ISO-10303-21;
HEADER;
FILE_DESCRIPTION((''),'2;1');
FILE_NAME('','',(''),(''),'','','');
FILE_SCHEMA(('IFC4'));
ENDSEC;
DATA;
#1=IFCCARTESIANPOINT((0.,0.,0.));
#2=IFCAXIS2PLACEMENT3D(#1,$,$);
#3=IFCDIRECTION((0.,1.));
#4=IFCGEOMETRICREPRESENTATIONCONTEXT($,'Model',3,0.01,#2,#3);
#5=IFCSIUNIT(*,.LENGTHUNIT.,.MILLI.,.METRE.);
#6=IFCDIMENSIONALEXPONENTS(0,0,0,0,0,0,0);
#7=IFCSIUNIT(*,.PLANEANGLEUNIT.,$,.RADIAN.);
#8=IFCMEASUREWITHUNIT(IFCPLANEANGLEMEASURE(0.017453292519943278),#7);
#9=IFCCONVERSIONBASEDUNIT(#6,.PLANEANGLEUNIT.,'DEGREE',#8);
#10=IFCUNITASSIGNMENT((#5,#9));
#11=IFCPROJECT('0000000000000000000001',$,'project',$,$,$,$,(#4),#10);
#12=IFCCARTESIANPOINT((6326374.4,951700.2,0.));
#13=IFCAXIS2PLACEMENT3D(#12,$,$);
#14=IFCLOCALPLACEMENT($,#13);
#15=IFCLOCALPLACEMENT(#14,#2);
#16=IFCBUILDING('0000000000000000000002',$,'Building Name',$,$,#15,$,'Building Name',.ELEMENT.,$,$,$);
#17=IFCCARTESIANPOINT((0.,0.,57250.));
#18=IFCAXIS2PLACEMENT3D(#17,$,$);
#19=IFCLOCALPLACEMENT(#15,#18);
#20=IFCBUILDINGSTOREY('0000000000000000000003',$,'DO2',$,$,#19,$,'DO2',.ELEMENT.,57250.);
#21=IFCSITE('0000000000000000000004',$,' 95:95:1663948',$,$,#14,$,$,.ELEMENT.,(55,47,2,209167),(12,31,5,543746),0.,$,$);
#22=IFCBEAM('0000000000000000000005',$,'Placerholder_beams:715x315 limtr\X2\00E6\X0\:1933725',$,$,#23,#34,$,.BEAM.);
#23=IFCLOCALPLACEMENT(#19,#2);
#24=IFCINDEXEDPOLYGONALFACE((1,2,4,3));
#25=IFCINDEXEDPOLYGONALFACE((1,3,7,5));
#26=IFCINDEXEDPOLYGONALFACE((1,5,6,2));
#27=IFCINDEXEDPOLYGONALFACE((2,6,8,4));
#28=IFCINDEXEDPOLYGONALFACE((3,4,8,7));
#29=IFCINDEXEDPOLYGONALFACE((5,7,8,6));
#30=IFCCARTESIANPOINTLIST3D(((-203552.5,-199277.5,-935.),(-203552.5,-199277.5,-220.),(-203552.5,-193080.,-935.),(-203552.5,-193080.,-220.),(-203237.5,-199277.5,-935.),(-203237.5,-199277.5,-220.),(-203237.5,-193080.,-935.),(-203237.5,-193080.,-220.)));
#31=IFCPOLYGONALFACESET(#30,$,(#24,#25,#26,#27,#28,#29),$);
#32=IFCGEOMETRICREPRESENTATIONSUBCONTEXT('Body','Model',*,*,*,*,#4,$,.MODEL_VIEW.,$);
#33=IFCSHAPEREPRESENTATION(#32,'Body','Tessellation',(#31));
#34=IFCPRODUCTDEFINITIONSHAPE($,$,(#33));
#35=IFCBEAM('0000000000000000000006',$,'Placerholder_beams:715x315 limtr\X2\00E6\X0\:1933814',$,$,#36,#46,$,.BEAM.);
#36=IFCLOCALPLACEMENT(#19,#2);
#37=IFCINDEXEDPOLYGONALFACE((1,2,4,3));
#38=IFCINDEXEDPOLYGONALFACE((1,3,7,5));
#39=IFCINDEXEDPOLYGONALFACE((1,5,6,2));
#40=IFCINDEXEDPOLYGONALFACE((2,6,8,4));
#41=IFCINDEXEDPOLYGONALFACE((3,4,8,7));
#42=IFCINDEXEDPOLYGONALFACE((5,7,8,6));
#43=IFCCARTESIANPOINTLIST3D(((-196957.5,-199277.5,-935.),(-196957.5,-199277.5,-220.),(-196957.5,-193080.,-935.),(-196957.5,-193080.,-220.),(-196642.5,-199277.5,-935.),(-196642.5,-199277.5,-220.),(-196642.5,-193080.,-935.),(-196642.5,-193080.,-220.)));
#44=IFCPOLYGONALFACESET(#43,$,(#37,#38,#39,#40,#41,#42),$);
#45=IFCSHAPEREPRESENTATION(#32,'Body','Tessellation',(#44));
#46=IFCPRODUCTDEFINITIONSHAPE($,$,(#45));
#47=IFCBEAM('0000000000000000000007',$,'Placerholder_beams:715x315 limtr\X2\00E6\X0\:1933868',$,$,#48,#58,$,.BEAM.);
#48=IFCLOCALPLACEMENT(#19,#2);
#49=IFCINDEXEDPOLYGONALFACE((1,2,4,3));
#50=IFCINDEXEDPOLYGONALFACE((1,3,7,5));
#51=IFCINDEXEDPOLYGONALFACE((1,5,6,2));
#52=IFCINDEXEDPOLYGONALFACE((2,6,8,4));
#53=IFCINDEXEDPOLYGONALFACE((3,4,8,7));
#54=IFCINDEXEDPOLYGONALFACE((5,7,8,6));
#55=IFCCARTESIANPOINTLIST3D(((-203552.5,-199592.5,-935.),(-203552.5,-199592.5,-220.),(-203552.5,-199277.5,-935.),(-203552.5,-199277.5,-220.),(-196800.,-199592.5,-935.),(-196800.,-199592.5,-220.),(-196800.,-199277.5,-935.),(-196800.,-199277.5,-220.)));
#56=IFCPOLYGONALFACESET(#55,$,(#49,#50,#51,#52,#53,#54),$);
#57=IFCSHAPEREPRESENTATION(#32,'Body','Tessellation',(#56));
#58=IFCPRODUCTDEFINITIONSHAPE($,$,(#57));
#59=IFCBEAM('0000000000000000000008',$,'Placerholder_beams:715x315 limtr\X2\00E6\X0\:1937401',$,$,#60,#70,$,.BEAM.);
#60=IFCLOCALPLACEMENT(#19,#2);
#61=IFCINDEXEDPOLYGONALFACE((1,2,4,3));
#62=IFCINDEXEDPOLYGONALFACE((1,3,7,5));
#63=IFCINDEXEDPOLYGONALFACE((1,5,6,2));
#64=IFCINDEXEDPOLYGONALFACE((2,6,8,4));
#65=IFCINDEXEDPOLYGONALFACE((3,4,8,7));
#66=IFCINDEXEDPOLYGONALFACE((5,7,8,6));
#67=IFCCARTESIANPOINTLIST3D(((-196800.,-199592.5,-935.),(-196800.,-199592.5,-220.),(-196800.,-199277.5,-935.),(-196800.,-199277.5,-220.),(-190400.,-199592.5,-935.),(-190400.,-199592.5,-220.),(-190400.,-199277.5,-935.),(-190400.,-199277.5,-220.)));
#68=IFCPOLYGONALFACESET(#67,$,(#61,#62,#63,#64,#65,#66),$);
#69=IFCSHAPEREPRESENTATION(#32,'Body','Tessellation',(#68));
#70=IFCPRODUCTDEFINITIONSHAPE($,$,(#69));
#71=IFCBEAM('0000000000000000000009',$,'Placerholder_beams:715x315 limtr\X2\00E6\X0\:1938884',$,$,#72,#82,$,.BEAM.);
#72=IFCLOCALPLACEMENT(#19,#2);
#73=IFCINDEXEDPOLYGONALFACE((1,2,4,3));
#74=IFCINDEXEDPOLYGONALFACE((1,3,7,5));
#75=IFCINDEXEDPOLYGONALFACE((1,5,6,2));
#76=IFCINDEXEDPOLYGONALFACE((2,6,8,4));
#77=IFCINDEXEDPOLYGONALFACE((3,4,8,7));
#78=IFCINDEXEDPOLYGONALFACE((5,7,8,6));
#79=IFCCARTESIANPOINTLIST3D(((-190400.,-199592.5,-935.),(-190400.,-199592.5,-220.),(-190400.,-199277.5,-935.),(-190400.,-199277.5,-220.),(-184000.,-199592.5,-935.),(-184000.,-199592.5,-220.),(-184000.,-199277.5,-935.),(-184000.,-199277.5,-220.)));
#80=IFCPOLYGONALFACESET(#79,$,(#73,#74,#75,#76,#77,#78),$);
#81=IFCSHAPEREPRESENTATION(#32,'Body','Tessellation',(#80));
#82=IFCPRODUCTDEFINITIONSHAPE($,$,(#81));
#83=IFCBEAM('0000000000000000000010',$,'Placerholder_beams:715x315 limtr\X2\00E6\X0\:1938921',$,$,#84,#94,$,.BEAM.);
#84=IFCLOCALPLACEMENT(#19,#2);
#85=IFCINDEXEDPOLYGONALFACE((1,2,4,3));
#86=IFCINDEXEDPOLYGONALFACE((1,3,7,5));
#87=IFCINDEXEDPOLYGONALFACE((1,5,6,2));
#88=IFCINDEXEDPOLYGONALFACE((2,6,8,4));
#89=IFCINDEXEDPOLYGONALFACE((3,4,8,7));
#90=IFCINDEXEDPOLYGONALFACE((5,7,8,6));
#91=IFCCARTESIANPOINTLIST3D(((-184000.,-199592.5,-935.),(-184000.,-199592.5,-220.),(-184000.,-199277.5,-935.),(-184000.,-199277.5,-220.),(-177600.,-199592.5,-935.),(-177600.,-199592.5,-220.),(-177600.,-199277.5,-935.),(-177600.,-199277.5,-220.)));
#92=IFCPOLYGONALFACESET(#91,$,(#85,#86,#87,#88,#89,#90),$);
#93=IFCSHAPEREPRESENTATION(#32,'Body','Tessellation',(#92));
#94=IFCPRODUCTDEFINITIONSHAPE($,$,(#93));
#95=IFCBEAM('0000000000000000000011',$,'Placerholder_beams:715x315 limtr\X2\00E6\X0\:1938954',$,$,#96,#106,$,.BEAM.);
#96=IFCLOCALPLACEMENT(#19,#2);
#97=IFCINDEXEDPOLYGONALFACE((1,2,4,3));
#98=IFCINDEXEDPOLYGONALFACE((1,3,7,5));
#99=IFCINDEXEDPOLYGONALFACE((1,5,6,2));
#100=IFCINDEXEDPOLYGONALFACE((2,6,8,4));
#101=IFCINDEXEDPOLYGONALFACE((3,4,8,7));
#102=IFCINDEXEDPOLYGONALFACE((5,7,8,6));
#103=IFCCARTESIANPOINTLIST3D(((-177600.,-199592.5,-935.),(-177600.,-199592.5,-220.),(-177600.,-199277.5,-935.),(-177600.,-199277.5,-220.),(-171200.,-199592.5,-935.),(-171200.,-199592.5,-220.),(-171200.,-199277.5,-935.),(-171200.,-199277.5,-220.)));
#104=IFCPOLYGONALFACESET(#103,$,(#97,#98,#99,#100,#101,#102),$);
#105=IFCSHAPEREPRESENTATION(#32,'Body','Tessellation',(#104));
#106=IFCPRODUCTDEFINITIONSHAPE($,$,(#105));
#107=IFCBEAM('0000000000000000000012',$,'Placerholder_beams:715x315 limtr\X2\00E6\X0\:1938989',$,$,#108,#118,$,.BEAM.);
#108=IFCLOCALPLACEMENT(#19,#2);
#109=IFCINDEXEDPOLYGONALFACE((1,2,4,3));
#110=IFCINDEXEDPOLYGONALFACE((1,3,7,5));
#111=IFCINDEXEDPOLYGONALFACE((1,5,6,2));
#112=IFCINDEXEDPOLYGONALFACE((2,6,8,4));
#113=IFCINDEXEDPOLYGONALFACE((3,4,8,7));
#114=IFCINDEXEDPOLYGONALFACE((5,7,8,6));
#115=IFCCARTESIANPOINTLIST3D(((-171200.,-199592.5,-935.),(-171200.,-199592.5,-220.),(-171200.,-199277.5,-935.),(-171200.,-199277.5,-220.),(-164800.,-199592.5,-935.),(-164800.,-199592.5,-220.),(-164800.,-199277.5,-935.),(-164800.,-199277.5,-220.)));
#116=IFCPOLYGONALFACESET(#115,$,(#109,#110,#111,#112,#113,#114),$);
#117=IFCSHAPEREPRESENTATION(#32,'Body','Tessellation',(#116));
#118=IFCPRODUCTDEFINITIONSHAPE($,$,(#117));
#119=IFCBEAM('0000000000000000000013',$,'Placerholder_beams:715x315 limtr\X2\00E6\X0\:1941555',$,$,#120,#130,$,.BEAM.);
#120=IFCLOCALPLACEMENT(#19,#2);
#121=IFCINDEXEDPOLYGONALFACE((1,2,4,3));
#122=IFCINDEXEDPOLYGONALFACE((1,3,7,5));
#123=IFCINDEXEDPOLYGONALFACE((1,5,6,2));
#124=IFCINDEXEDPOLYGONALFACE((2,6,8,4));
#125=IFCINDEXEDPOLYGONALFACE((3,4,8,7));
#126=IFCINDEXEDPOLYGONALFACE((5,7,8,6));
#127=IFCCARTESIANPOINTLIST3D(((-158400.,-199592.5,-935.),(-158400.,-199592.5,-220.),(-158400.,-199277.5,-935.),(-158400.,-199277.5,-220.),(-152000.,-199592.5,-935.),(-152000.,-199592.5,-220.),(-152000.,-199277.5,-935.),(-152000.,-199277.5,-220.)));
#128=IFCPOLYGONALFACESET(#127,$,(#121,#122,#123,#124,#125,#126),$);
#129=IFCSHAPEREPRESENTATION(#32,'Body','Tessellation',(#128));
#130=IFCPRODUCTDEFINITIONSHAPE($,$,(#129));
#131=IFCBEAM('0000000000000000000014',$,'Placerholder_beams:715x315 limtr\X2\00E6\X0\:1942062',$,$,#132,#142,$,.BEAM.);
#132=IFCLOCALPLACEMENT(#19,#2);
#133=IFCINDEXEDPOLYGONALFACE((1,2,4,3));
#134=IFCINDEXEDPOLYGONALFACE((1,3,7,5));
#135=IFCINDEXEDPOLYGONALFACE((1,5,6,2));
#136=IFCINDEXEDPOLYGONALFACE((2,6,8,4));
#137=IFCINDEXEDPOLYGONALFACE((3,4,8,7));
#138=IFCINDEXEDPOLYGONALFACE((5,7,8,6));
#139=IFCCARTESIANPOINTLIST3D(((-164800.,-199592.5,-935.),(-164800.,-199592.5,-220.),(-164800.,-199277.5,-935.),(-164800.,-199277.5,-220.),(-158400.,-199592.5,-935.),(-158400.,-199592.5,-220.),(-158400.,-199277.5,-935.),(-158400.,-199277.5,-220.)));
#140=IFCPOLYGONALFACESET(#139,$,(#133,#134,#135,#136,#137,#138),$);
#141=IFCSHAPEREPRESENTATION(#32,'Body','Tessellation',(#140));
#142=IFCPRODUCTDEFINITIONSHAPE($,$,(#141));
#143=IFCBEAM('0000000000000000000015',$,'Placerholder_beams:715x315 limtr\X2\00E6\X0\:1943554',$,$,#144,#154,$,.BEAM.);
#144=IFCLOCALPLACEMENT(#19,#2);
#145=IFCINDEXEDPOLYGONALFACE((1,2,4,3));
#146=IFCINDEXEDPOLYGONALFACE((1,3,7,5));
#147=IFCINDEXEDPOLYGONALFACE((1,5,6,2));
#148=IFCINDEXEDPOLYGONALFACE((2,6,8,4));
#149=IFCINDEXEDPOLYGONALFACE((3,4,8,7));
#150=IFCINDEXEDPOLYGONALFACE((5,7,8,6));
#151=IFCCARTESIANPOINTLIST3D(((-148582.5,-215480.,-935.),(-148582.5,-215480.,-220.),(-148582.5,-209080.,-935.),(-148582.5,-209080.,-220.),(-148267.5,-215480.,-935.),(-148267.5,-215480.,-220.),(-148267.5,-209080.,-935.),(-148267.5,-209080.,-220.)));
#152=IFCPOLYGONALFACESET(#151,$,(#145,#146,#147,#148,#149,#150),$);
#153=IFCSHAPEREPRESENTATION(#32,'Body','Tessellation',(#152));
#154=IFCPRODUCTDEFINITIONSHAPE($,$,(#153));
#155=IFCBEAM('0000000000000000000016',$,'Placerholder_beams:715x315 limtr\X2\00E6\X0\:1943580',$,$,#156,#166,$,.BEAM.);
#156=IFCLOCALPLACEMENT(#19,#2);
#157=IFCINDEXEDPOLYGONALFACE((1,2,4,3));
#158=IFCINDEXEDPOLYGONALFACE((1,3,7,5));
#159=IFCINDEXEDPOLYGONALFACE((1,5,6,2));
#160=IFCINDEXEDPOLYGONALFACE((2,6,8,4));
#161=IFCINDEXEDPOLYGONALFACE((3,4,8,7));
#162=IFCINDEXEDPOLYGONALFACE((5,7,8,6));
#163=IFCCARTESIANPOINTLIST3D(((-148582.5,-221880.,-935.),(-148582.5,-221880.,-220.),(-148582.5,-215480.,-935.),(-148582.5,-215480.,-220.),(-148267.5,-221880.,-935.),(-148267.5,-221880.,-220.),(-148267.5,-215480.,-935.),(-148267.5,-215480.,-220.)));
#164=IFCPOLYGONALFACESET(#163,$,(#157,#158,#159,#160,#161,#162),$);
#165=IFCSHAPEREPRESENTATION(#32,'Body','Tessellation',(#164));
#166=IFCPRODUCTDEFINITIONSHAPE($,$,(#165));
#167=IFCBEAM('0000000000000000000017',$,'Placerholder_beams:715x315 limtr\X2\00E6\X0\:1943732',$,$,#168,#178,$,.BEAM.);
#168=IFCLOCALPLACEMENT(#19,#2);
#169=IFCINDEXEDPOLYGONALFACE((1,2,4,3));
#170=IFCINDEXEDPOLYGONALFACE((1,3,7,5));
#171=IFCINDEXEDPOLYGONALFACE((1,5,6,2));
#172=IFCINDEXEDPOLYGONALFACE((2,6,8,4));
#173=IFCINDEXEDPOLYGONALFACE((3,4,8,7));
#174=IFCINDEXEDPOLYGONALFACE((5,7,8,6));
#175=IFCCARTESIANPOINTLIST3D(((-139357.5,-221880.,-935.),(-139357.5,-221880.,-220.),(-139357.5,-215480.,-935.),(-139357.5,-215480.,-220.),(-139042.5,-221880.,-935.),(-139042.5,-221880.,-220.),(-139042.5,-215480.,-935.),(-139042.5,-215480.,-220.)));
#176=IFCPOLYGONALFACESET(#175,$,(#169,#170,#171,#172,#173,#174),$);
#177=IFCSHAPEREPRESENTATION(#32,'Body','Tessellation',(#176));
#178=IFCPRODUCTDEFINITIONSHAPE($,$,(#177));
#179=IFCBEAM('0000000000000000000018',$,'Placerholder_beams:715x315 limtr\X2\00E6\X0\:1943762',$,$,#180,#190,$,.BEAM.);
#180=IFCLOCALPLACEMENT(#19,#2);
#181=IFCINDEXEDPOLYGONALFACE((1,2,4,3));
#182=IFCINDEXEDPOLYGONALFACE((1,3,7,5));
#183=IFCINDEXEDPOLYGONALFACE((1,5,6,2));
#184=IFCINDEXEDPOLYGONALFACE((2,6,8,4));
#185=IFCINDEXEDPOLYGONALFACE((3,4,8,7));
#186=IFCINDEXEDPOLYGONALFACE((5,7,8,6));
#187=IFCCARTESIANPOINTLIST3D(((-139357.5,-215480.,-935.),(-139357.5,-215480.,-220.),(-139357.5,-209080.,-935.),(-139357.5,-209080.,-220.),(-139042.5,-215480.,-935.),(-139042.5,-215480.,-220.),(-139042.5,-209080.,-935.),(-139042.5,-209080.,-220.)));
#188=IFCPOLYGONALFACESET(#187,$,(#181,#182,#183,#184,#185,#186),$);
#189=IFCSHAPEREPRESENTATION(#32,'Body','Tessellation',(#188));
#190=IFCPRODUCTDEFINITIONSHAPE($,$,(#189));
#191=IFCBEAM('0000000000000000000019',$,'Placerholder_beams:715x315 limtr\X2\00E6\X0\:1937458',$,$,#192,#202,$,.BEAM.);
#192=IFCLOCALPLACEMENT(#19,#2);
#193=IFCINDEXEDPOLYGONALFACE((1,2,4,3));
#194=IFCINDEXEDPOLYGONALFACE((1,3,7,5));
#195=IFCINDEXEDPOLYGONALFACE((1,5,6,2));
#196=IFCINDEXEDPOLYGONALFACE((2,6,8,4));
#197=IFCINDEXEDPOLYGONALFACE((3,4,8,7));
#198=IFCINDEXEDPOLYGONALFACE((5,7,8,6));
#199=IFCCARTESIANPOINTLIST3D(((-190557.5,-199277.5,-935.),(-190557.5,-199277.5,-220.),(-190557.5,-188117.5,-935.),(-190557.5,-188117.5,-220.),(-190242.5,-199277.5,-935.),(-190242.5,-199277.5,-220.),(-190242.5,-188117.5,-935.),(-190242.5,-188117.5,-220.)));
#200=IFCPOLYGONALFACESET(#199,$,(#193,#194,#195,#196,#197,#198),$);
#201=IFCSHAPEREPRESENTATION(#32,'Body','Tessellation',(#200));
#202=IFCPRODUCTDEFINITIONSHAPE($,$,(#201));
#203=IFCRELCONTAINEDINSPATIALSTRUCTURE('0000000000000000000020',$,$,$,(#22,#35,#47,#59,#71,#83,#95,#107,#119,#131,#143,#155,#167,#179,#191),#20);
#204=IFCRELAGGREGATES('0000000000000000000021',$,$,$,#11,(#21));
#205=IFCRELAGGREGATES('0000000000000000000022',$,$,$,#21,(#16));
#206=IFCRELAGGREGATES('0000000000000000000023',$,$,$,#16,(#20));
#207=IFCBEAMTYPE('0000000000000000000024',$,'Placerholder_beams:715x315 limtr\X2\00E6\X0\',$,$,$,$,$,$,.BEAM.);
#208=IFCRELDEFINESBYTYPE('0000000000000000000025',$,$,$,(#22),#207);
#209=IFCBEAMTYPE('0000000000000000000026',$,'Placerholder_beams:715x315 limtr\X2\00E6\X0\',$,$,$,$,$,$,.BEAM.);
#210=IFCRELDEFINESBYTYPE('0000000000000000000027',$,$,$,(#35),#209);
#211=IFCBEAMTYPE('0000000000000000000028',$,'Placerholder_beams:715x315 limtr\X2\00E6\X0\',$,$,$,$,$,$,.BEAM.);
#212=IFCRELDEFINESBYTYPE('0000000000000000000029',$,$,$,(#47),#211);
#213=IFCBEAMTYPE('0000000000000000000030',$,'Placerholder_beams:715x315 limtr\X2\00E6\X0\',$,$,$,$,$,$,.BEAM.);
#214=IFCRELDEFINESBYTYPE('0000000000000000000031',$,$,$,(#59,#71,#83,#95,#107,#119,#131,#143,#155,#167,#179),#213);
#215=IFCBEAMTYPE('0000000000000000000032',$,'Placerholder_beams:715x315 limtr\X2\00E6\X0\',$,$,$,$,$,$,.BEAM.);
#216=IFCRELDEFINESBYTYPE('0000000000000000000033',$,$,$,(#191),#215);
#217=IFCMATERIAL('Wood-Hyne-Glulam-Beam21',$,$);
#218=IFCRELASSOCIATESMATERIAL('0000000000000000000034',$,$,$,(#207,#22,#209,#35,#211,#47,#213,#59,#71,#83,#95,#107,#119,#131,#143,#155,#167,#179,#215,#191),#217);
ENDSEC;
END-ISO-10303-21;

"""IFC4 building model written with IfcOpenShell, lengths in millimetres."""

from ifc_helpers import new_model, entity, si_unit, converted_unit, direction, frame, origin, place, context, subcontext, project, spatial, indexed_curve, outline, extrude, source, transform, mapped, material, type_object, type_shapes, element, save


model = new_model("IFC4")

# Units and contexts
model_context = context("Model", 3, precision=0.01, world=origin(), true_north=direction((0.0, 1.0)))
body_context = subcontext(model_context, "Body", "Model", "MODEL_VIEW")
ifc_project = project(units=[si_unit("LENGTHUNIT", "METRE", prefix="MILLI"), converted_unit("PLANEANGLEUNIT", "DEGREE", entity("IfcPlaneAngleMeasure", 0.017453292519943278), si_unit("PLANEANGLEUNIT", "RADIAN"), dimensions=[0, 0, 0, 0, 0, 0, 0])], contexts=[model_context])

# Site, building, storey
site_placement = place(None, frame((6326374.4, 951700.2, 0.0)))
site = spatial("IfcSite", under=ifc_project, at=site_placement, Name=" 95:95:1663948", CompositionType="ELEMENT", RefLatitude=(55, 47, 2, 209167), RefLongitude=(12, 31, 5, 543746), RefElevation=0.0)
building_placement = place(site_placement, origin())
building = spatial("IfcBuilding", under=site, at=building_placement, Name="Building Name", LongName="Building Name", CompositionType="ELEMENT")
storey_placement = place(building_placement, frame((0.0, 0.0, 57250.0)))
storey = spatial("IfcBuildingStorey", under=building, at=storey_placement, Name="DO2", LongName="DO2", CompositionType="ELEMENT", Elevation=57250.0)

# Beams
ifc_material = material(Name="Wood-Hyne-Glulam-Beam21")
beam_type_1 = type_object("IfcBeamType", Name="Placerholder_beams:715x315 limtræ", PredefinedType="BEAM", material=ifc_material)
shared_shape_1 = source(origin(), body_context, "Body", "SweptSolid", [
    extrude(outline(indexed_curve([(-3098.7, -157.5), (3098.7, -157.5), (3098.7, 157.5), (-3098.7, 157.5), (-3098.7, -157.5)], self_intersect=False)), frame((28.8, 0.0, -357.5)), (0.0, 0.0, 1.0), 715.0),
])
type_shapes(beam_type_1, [shared_shape_1])
beam_1_placement = place(storey_placement, frame((-203395.0, -196207.5, -577.5), z_axis=(0.0, 0.0, 1.0), x_axis=(0.0, 1.0, 0.0)))
element("IfcBeam", 1, at=beam_1_placement, inside=storey, type_object=beam_type_1, material=ifc_material, Name="Placerholder_beams:715x315 limtræ:1933725", PredefinedType="BEAM", context=body_context, shape_type="MappedRepresentation", body=[
    mapped(shared_shape_1, transform((0.0, 0.0, 0.0), scale=1.0)),
])
beam_type_2 = type_object("IfcBeamType", Name="Placerholder_beams:715x315 limtræ", PredefinedType="BEAM", material=ifc_material)
shared_shape_2 = source(origin(), body_context, "Body", "SweptSolid", [
    extrude(outline(indexed_curve([(-3098.7, -157.5), (3098.7, -157.5), (3098.7, 157.5), (-3098.7, 157.5), (-3098.7, -157.5)], self_intersect=False)), frame((78.8, 0.0, -357.5)), (0.0, 0.0, 1.0), 715.0),
])
type_shapes(beam_type_2, [shared_shape_2])
beam_2_placement = place(storey_placement, frame((-196800.0, -196257.5, -577.5), z_axis=(0.0, 0.0, 1.0), x_axis=(0.0, 1.0, 0.0)))
element("IfcBeam", 2, at=beam_2_placement, inside=storey, type_object=beam_type_2, material=ifc_material, Name="Placerholder_beams:715x315 limtræ:1933814", PredefinedType="BEAM", context=body_context, shape_type="MappedRepresentation", body=[
    mapped(shared_shape_2, transform((0.0, 0.0, 0.0), scale=1.0)),
])
beam_type_3 = type_object("IfcBeamType", Name="Placerholder_beams:715x315 limtræ", PredefinedType="BEAM", material=ifc_material)
shared_shape_3 = source(origin(), body_context, "Body", "SweptSolid", [
    extrude(outline(indexed_curve([(-3376.2, -157.5), (3376.2, -157.5), (3376.2, 157.5), (-3376.2, 157.5), (-3376.2, -157.5)], self_intersect=False)), frame((78.7, 0.0, -357.5)), (0.0, 0.0, 1.0), 715.0),
])
type_shapes(beam_type_3, [shared_shape_3])
beam_3_placement = place(storey_placement, frame((-200097.5, -199435.0, -577.5), z_axis=(0.0, 0.0, 1.0), x_axis=(-1.0, 0.0, 0.0)))
element("IfcBeam", 3, at=beam_3_placement, inside=storey, type_object=beam_type_3, material=ifc_material, Name="Placerholder_beams:715x315 limtræ:1933868", PredefinedType="BEAM", context=body_context, shape_type="MappedRepresentation", body=[
    mapped(shared_shape_3, transform((0.0, 0.0, 0.0), scale=1.0)),
])
beam_type_4 = type_object("IfcBeamType", Name="Placerholder_beams:715x315 limtræ", PredefinedType="BEAM", material=ifc_material)
shared_shape_4 = source(origin(), body_context, "Body", "SweptSolid", [
    extrude(outline(indexed_curve([(-3200.0, -157.5), (3200.0, -157.5), (3200.0, 157.5), (-3200.0, 157.5), (-3200.0, -157.5)], self_intersect=False)), frame((0.0, 0.0, -357.5)), (0.0, 0.0, 1.0), 715.0),
])
type_shapes(beam_type_4, [shared_shape_4])
for number, where, name in (
    (4, (-193600.0, -199435.0, -577.5), "Placerholder_beams:715x315 limtræ:1937401"),
    (5, (-187200.0, -199435.0, -577.5), "Placerholder_beams:715x315 limtræ:1938884"),
    (6, (-180800.0, -199435.0, -577.5), "Placerholder_beams:715x315 limtræ:1938921"),
    (7, (-174400.0, -199435.0, -577.5), "Placerholder_beams:715x315 limtræ:1938954"),
    (8, (-168000.0, -199435.0, -577.5), "Placerholder_beams:715x315 limtræ:1938989"),
):
    element("IfcBeam", number, at=place(storey_placement, frame(where)), inside=storey, type_object=beam_type_4, material=ifc_material, Name=name, PredefinedType="BEAM", context=body_context, shape_type="MappedRepresentation", body=[
        mapped(shared_shape_4, transform((0.0, 0.0, 0.0), scale=1.0)),
    ])
beam_4_placement = place(storey_placement, frame((-155200.0, -199435.0, -577.5), z_axis=(0.0, 0.0, 1.0), x_axis=(-1.0, 0.0, 0.0)))
element("IfcBeam", 9, at=beam_4_placement, inside=storey, type_object=beam_type_4, material=ifc_material, Name="Placerholder_beams:715x315 limtræ:1941555", PredefinedType="BEAM", context=body_context, shape_type="MappedRepresentation", body=[
    mapped(shared_shape_4, transform((0.0, 0.0, 0.0), scale=1.0)),
])
beam_5_placement = place(storey_placement, frame((-161600.0, -199435.0, -577.5)))
element("IfcBeam", 10, at=beam_5_placement, inside=storey, type_object=beam_type_4, material=ifc_material, Name="Placerholder_beams:715x315 limtræ:1942062", PredefinedType="BEAM", context=body_context, shape_type="MappedRepresentation", body=[
    mapped(shared_shape_4, transform((0.0, 0.0, 0.0), scale=1.0)),
])
for number, where, z_axis, x_axis, name in (
    (11, (-148425.0, -212280.0, -577.5), (0.0, 0.0, 1.0), (0.0, -1.0, 0.0), "Placerholder_beams:715x315 limtræ:1943554"),
    (12, (-148425.0, -218680.0, -577.5), (0.0, 0.0, 1.0), (0.0, -1.0, 0.0), "Placerholder_beams:715x315 limtræ:1943580"),
    (13, (-139200.0, -218680.0, -577.5), (0.0, 0.0, 1.0), (0.0, 1.0, 0.0), "Placerholder_beams:715x315 limtræ:1943732"),
    (14, (-139200.0, -212280.0, -577.5), (0.0, 0.0, 1.0), (0.0, 1.0, 0.0), "Placerholder_beams:715x315 limtræ:1943762"),
):
    element("IfcBeam", number, at=place(storey_placement, frame(where, z_axis=z_axis, x_axis=x_axis)), inside=storey, type_object=beam_type_4, material=ifc_material, Name=name, PredefinedType="BEAM", context=body_context, shape_type="MappedRepresentation", body=[
        mapped(shared_shape_4, transform((0.0, 0.0, 0.0), scale=1.0)),
    ])
beam_type_5 = type_object("IfcBeamType", Name="Placerholder_beams:715x315 limtræ", PredefinedType="BEAM", material=ifc_material)
shared_shape_5 = source(origin(), body_context, "Body", "SweptSolid", [
    extrude(outline(indexed_curve([(-5580.0, -157.5), (5580.0, -157.5), (5580.0, 157.5), (-5580.0, 157.5), (-5580.0, -157.5)], self_intersect=False)), frame((0.0, 0.0, -357.5)), (0.0, 0.0, 1.0), 715.0),
])
type_shapes(beam_type_5, [shared_shape_5])
for number, where, z_axis, x_axis, name in (
    (15, (-190400.0, -193697.5, -577.5), (0.0, 0.0, 1.0), (0.0, 1.0, 0.0), "Placerholder_beams:715x315 limtræ:1937458"),
):
    element("IfcBeam", number, at=place(storey_placement, frame(where, z_axis=z_axis, x_axis=x_axis)), inside=storey, type_object=beam_type_5, material=ifc_material, Name=name, PredefinedType="BEAM", context=body_context, shape_type="MappedRepresentation", body=[
        mapped(shared_shape_5, transform((0.0, 0.0, 0.0), scale=1.0)),
    ])

save(model, "model.ifc")
